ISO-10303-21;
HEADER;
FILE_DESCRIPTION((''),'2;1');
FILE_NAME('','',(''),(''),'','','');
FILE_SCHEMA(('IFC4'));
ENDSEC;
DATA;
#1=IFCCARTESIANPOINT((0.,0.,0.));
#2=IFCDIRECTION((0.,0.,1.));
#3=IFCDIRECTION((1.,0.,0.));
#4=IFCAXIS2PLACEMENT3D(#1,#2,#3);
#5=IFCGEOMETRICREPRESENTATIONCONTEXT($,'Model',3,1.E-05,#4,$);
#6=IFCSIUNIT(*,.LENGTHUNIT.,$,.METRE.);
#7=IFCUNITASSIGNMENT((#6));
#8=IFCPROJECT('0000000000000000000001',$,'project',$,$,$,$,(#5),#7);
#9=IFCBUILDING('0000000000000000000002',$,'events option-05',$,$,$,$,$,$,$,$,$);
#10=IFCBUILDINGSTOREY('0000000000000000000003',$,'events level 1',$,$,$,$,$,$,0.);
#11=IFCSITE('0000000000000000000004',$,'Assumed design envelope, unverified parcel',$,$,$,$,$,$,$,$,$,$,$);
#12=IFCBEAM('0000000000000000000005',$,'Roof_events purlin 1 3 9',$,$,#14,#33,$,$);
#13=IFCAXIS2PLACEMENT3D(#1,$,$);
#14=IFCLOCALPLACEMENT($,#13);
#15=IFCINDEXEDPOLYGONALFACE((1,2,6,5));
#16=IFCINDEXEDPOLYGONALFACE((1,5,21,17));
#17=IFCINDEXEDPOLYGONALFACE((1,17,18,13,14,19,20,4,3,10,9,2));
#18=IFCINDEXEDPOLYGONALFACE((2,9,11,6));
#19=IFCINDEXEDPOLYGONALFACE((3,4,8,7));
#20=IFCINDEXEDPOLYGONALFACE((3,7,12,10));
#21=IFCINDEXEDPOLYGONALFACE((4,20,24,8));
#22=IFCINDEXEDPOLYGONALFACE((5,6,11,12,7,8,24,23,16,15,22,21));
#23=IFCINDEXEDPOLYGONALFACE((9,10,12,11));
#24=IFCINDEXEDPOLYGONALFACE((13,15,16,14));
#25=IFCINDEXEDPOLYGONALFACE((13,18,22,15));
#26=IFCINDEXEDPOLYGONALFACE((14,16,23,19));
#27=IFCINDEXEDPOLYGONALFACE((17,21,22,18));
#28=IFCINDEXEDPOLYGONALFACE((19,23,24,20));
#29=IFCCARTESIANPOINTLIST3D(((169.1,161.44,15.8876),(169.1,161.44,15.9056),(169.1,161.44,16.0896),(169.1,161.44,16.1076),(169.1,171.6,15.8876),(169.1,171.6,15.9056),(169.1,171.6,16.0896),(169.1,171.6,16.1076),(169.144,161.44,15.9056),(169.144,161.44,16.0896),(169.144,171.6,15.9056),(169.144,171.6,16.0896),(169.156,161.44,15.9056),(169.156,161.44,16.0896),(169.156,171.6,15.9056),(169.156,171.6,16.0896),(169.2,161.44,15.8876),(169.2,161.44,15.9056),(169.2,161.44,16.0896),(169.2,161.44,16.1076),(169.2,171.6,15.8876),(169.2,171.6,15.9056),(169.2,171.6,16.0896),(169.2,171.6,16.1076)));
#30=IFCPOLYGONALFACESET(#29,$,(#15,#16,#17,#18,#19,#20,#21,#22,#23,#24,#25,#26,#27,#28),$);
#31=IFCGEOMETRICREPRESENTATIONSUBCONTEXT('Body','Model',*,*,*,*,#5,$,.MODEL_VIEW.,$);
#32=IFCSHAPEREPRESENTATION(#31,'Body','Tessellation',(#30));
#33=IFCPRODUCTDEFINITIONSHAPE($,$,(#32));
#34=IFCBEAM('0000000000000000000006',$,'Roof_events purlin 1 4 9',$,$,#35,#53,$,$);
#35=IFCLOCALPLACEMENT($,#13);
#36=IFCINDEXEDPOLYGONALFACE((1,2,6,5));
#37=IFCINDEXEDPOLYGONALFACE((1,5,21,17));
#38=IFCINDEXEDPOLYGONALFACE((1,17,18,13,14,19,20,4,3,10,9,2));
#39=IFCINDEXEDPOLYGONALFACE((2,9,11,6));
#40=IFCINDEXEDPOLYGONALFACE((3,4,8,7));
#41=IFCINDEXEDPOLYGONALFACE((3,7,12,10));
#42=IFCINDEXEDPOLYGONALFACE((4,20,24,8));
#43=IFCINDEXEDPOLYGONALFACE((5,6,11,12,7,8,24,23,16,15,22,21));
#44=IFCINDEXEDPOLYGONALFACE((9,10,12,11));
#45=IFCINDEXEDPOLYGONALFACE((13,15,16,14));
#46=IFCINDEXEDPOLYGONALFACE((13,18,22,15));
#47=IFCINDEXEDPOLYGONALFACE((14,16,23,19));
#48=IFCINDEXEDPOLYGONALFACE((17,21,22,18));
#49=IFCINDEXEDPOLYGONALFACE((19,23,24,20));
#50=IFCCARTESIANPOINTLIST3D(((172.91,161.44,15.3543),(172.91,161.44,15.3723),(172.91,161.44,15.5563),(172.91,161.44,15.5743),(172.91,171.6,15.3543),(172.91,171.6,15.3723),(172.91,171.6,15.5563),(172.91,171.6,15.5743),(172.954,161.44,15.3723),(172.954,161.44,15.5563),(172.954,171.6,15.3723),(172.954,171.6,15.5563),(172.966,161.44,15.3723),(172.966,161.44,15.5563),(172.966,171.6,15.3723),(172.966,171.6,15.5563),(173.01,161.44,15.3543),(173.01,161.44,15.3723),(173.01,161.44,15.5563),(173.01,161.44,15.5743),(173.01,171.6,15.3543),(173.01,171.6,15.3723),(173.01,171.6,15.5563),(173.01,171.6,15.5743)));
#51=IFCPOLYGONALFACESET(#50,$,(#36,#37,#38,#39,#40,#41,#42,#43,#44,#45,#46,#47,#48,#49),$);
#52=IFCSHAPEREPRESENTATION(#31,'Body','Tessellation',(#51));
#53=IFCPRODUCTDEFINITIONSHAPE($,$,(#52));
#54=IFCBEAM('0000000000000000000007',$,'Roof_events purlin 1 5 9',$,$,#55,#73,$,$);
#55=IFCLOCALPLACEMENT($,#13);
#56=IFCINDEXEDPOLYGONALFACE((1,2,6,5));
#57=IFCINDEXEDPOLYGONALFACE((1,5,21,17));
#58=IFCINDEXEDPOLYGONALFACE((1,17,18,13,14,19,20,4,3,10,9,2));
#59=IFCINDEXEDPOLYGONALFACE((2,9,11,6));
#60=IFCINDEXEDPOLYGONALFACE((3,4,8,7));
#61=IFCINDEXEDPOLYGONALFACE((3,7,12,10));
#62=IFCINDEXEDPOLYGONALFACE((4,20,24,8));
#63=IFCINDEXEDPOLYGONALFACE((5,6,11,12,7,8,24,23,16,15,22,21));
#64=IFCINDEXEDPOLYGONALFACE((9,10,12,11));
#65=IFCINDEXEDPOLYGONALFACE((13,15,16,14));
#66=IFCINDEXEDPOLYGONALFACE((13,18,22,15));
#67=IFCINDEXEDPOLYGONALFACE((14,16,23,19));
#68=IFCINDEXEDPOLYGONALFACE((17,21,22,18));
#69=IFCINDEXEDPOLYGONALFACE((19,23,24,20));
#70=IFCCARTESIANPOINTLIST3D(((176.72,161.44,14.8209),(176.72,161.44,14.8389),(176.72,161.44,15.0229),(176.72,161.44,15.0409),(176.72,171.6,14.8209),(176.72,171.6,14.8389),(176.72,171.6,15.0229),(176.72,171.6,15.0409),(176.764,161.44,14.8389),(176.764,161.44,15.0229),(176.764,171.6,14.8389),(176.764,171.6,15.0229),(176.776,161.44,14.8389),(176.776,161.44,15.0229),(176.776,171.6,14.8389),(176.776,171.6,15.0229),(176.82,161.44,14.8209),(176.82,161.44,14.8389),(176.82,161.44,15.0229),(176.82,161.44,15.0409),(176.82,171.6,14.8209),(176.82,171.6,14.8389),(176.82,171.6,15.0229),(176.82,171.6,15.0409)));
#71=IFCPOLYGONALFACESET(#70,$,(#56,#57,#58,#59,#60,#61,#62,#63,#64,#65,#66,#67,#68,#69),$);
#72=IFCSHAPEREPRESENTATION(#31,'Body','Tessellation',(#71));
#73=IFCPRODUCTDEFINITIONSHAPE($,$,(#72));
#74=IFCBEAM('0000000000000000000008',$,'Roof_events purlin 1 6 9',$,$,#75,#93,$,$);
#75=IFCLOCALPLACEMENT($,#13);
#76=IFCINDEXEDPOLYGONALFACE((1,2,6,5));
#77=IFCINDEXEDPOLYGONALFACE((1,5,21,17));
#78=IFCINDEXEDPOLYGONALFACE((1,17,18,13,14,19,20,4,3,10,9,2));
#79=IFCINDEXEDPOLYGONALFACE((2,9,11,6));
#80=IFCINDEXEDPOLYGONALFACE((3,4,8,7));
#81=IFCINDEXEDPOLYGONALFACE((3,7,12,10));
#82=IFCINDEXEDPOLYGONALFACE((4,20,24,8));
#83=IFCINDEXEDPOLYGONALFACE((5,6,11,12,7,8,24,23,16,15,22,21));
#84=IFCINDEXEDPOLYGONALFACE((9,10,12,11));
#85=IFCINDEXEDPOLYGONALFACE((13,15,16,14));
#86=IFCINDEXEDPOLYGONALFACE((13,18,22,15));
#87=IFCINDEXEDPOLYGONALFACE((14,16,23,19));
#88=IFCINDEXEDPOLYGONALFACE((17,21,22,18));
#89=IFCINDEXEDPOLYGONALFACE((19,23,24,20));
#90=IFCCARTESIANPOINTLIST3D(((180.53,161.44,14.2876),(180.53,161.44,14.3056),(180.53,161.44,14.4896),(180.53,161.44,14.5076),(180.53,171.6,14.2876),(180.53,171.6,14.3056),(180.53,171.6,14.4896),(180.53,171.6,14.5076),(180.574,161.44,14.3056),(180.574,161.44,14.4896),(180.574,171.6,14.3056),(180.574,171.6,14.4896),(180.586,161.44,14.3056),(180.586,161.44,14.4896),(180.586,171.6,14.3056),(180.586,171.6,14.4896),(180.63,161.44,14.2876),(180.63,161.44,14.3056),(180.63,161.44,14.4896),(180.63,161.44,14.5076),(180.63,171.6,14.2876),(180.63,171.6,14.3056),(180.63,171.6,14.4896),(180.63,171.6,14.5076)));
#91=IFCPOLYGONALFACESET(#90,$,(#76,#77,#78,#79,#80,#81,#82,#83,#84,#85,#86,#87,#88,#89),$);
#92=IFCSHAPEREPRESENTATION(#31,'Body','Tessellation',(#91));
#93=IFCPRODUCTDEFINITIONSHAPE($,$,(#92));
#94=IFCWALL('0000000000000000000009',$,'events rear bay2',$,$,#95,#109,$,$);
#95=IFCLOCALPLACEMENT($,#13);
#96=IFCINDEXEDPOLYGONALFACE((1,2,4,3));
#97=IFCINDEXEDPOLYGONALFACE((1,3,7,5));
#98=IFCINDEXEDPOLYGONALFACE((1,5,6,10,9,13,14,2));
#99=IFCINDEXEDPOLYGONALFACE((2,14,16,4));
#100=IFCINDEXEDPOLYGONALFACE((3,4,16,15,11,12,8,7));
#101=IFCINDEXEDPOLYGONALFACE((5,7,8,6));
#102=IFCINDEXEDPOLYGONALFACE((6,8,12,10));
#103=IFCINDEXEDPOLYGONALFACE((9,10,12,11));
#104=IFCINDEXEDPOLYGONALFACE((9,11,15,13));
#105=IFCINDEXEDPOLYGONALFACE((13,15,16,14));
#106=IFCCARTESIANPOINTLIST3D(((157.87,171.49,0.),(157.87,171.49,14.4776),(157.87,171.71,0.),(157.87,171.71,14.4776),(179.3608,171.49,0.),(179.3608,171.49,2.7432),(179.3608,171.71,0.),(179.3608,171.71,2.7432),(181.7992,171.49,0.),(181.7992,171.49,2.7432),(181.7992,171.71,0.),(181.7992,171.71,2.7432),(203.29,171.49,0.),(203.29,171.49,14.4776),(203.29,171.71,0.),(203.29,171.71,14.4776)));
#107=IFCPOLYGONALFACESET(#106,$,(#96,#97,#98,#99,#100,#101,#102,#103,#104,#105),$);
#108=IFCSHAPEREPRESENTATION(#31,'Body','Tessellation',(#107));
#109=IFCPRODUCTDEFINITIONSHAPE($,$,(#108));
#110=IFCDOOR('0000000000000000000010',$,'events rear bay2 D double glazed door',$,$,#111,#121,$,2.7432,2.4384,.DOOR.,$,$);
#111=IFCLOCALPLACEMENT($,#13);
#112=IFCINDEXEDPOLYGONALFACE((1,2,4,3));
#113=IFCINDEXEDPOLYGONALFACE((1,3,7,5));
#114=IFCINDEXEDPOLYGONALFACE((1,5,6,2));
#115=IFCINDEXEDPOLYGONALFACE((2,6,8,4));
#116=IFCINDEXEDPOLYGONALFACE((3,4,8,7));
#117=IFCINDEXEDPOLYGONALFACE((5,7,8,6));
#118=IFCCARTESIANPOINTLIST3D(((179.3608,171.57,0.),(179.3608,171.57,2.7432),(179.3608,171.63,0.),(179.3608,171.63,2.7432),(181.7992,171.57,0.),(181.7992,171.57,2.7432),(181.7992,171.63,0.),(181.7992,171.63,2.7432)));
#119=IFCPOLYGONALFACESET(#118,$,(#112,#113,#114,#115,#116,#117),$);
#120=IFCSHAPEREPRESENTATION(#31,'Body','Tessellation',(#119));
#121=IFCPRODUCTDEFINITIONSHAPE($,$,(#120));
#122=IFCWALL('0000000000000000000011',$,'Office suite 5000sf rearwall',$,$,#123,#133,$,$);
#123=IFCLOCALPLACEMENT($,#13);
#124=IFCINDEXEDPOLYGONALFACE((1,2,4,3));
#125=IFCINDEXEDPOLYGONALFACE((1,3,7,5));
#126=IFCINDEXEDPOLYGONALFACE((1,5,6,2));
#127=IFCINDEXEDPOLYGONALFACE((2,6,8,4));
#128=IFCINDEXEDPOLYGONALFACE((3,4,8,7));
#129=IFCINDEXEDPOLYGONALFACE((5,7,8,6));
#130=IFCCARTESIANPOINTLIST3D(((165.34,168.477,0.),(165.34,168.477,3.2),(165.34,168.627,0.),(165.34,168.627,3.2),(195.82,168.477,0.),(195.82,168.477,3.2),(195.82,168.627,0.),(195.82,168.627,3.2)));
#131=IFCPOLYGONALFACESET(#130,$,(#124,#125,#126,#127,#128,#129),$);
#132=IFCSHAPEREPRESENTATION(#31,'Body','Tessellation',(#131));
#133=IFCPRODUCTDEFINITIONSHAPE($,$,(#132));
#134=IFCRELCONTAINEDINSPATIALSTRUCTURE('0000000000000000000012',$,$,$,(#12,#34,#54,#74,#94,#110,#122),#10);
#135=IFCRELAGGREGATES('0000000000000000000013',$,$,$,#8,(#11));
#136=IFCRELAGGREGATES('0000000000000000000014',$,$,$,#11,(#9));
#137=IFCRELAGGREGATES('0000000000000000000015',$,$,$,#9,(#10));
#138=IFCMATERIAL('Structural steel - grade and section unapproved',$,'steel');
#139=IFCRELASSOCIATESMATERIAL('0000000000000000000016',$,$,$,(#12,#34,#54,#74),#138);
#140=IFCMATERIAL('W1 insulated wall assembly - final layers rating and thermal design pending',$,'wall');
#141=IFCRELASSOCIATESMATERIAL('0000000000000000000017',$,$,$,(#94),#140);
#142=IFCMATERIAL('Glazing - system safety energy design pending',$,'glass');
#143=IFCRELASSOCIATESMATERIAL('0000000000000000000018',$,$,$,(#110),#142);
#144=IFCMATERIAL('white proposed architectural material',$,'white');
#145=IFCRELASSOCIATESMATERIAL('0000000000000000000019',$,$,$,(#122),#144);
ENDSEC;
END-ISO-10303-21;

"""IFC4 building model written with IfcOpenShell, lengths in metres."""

from ifc_helpers import new_model, si_unit, frame, origin_with_axes, place, context, subcontext, project, spatial, rectangle, i_section, extrude, material, element, fill, save


model = new_model("IFC4")

# Units and contexts
model_context = context("Model", 3, precision=1e-05, world=origin_with_axes())
body_context = subcontext(model_context, "Body", "Model", "MODEL_VIEW")
ifc_project = project(units=[si_unit("LENGTHUNIT", "METRE")], contexts=[model_context])

# Site, building, storey
site = spatial("IfcSite", under=ifc_project, Name="Assumed design envelope, unverified parcel")
building = spatial("IfcBuilding", under=site, Name="events option-05")
storey = spatial("IfcBuildingStorey", under=building, Name="events level 1", Elevation=0.0)

# Beams
ifc_material_1 = material(Name="Structural steel - grade and section unapproved", Category="steel")
for number, where, z_axis, x_axis, name in (
    (1, (169.15, 161.44, 15.9976), (0.0, 1.0, 0.0), (-1.0, 0.0, 0.0), "Roof_events purlin 1 3 9"),
    (2, (172.96, 161.44, 15.4643), (0.0, 1.0, 0.0), (-1.0, 0.0, 0.0), "Roof_events purlin 1 4 9"),
    (3, (176.77, 161.44, 14.9309), (0.0, 1.0, 0.0), (-1.0, 0.0, 0.0), "Roof_events purlin 1 5 9"),
    (4, (180.58, 161.44, 14.3976), (0.0, 1.0, 0.0), (-1.0, 0.0, 0.0), "Roof_events purlin 1 6 9"),
):
    element("IfcBeam", number, at=place(None, frame(where, z_axis=z_axis, x_axis=x_axis)), inside=storey, material=ifc_material_1, Name=name, context=body_context, shape_type="SweptSolid", body=[
        extrude(i_section(OverallWidth=0.1, OverallDepth=0.22, WebThickness=0.012, FlangeThickness=0.018, FilletRadius=0.0), origin_with_axes(), (0.0, 0.0, 1.0), 10.16),
    ])

# Wall, opening, door
ifc_material_2 = material(Name="W1 insulated wall assembly - final layers rating and thermal design pending", Category="wall")
wall_1_placement = place(None, frame((180.58, 171.6, 0.0), z_axis=(0.0, 0.0, 1.0), x_axis=(1.0, 0.0, 0.0)))
wall_1 = element("IfcWall", 5, at=wall_1_placement, inside=storey, material=ifc_material_2, Name="events rear bay2", context=body_context, shape_type="SweptSolid", body=[
    extrude(rectangle(XDim=45.42, YDim=0.22), origin_with_axes(), (0.0, 0.0, 1.0), 14.4776),
])
opening_placement = place(None, frame((180.58, 171.6, 0.0), z_axis=(0.0, 0.0, 1.0), x_axis=(1.0, 0.0, 0.0)))
opening = element("IfcOpeningElement", 6, at=opening_placement, cuts=wall_1, context=body_context, shape_type="SweptSolid", body=[
    extrude(rectangle(XDim=2.4384, YDim=0.32), origin_with_axes(), (0.0, 0.0, 1.0), 2.7432),
])
ifc_material_3 = material(Name="Glazing - system safety energy design pending", Category="glass")
door_placement = place(None, frame((180.58, 171.6, 0.0), z_axis=(0.0, 0.0, 1.0), x_axis=(1.0, 0.0, 0.0)))
door = element("IfcDoor", 7, at=door_placement, inside=storey, material=ifc_material_3, Name="events rear bay2 D double glazed door", OverallHeight=2.7432, OverallWidth=2.4384, PredefinedType="DOOR", context=body_context, shape_type="SweptSolid", body=[
    extrude(rectangle(XDim=2.4384, YDim=0.06), origin_with_axes(), (0.0, 0.0, 1.0), 2.7432),
])
fill(opening, door)

# Wall
ifc_material_4 = material(Name="white proposed architectural material", Category="white")
wall_2_placement = place(None, frame((180.58, 168.552, 0.0), z_axis=(0.0, 0.0, 1.0), x_axis=(1.0, 0.0, 0.0)))
element("IfcWall", 8, at=wall_2_placement, inside=storey, material=ifc_material_4, Name="Office suite 5000sf rearwall", context=body_context, shape_type="SweptSolid", body=[
    extrude(rectangle(XDim=30.48, YDim=0.15), origin_with_axes(), (0.0, 0.0, 1.0), 3.2),
])

save(model, "model.ifc")
